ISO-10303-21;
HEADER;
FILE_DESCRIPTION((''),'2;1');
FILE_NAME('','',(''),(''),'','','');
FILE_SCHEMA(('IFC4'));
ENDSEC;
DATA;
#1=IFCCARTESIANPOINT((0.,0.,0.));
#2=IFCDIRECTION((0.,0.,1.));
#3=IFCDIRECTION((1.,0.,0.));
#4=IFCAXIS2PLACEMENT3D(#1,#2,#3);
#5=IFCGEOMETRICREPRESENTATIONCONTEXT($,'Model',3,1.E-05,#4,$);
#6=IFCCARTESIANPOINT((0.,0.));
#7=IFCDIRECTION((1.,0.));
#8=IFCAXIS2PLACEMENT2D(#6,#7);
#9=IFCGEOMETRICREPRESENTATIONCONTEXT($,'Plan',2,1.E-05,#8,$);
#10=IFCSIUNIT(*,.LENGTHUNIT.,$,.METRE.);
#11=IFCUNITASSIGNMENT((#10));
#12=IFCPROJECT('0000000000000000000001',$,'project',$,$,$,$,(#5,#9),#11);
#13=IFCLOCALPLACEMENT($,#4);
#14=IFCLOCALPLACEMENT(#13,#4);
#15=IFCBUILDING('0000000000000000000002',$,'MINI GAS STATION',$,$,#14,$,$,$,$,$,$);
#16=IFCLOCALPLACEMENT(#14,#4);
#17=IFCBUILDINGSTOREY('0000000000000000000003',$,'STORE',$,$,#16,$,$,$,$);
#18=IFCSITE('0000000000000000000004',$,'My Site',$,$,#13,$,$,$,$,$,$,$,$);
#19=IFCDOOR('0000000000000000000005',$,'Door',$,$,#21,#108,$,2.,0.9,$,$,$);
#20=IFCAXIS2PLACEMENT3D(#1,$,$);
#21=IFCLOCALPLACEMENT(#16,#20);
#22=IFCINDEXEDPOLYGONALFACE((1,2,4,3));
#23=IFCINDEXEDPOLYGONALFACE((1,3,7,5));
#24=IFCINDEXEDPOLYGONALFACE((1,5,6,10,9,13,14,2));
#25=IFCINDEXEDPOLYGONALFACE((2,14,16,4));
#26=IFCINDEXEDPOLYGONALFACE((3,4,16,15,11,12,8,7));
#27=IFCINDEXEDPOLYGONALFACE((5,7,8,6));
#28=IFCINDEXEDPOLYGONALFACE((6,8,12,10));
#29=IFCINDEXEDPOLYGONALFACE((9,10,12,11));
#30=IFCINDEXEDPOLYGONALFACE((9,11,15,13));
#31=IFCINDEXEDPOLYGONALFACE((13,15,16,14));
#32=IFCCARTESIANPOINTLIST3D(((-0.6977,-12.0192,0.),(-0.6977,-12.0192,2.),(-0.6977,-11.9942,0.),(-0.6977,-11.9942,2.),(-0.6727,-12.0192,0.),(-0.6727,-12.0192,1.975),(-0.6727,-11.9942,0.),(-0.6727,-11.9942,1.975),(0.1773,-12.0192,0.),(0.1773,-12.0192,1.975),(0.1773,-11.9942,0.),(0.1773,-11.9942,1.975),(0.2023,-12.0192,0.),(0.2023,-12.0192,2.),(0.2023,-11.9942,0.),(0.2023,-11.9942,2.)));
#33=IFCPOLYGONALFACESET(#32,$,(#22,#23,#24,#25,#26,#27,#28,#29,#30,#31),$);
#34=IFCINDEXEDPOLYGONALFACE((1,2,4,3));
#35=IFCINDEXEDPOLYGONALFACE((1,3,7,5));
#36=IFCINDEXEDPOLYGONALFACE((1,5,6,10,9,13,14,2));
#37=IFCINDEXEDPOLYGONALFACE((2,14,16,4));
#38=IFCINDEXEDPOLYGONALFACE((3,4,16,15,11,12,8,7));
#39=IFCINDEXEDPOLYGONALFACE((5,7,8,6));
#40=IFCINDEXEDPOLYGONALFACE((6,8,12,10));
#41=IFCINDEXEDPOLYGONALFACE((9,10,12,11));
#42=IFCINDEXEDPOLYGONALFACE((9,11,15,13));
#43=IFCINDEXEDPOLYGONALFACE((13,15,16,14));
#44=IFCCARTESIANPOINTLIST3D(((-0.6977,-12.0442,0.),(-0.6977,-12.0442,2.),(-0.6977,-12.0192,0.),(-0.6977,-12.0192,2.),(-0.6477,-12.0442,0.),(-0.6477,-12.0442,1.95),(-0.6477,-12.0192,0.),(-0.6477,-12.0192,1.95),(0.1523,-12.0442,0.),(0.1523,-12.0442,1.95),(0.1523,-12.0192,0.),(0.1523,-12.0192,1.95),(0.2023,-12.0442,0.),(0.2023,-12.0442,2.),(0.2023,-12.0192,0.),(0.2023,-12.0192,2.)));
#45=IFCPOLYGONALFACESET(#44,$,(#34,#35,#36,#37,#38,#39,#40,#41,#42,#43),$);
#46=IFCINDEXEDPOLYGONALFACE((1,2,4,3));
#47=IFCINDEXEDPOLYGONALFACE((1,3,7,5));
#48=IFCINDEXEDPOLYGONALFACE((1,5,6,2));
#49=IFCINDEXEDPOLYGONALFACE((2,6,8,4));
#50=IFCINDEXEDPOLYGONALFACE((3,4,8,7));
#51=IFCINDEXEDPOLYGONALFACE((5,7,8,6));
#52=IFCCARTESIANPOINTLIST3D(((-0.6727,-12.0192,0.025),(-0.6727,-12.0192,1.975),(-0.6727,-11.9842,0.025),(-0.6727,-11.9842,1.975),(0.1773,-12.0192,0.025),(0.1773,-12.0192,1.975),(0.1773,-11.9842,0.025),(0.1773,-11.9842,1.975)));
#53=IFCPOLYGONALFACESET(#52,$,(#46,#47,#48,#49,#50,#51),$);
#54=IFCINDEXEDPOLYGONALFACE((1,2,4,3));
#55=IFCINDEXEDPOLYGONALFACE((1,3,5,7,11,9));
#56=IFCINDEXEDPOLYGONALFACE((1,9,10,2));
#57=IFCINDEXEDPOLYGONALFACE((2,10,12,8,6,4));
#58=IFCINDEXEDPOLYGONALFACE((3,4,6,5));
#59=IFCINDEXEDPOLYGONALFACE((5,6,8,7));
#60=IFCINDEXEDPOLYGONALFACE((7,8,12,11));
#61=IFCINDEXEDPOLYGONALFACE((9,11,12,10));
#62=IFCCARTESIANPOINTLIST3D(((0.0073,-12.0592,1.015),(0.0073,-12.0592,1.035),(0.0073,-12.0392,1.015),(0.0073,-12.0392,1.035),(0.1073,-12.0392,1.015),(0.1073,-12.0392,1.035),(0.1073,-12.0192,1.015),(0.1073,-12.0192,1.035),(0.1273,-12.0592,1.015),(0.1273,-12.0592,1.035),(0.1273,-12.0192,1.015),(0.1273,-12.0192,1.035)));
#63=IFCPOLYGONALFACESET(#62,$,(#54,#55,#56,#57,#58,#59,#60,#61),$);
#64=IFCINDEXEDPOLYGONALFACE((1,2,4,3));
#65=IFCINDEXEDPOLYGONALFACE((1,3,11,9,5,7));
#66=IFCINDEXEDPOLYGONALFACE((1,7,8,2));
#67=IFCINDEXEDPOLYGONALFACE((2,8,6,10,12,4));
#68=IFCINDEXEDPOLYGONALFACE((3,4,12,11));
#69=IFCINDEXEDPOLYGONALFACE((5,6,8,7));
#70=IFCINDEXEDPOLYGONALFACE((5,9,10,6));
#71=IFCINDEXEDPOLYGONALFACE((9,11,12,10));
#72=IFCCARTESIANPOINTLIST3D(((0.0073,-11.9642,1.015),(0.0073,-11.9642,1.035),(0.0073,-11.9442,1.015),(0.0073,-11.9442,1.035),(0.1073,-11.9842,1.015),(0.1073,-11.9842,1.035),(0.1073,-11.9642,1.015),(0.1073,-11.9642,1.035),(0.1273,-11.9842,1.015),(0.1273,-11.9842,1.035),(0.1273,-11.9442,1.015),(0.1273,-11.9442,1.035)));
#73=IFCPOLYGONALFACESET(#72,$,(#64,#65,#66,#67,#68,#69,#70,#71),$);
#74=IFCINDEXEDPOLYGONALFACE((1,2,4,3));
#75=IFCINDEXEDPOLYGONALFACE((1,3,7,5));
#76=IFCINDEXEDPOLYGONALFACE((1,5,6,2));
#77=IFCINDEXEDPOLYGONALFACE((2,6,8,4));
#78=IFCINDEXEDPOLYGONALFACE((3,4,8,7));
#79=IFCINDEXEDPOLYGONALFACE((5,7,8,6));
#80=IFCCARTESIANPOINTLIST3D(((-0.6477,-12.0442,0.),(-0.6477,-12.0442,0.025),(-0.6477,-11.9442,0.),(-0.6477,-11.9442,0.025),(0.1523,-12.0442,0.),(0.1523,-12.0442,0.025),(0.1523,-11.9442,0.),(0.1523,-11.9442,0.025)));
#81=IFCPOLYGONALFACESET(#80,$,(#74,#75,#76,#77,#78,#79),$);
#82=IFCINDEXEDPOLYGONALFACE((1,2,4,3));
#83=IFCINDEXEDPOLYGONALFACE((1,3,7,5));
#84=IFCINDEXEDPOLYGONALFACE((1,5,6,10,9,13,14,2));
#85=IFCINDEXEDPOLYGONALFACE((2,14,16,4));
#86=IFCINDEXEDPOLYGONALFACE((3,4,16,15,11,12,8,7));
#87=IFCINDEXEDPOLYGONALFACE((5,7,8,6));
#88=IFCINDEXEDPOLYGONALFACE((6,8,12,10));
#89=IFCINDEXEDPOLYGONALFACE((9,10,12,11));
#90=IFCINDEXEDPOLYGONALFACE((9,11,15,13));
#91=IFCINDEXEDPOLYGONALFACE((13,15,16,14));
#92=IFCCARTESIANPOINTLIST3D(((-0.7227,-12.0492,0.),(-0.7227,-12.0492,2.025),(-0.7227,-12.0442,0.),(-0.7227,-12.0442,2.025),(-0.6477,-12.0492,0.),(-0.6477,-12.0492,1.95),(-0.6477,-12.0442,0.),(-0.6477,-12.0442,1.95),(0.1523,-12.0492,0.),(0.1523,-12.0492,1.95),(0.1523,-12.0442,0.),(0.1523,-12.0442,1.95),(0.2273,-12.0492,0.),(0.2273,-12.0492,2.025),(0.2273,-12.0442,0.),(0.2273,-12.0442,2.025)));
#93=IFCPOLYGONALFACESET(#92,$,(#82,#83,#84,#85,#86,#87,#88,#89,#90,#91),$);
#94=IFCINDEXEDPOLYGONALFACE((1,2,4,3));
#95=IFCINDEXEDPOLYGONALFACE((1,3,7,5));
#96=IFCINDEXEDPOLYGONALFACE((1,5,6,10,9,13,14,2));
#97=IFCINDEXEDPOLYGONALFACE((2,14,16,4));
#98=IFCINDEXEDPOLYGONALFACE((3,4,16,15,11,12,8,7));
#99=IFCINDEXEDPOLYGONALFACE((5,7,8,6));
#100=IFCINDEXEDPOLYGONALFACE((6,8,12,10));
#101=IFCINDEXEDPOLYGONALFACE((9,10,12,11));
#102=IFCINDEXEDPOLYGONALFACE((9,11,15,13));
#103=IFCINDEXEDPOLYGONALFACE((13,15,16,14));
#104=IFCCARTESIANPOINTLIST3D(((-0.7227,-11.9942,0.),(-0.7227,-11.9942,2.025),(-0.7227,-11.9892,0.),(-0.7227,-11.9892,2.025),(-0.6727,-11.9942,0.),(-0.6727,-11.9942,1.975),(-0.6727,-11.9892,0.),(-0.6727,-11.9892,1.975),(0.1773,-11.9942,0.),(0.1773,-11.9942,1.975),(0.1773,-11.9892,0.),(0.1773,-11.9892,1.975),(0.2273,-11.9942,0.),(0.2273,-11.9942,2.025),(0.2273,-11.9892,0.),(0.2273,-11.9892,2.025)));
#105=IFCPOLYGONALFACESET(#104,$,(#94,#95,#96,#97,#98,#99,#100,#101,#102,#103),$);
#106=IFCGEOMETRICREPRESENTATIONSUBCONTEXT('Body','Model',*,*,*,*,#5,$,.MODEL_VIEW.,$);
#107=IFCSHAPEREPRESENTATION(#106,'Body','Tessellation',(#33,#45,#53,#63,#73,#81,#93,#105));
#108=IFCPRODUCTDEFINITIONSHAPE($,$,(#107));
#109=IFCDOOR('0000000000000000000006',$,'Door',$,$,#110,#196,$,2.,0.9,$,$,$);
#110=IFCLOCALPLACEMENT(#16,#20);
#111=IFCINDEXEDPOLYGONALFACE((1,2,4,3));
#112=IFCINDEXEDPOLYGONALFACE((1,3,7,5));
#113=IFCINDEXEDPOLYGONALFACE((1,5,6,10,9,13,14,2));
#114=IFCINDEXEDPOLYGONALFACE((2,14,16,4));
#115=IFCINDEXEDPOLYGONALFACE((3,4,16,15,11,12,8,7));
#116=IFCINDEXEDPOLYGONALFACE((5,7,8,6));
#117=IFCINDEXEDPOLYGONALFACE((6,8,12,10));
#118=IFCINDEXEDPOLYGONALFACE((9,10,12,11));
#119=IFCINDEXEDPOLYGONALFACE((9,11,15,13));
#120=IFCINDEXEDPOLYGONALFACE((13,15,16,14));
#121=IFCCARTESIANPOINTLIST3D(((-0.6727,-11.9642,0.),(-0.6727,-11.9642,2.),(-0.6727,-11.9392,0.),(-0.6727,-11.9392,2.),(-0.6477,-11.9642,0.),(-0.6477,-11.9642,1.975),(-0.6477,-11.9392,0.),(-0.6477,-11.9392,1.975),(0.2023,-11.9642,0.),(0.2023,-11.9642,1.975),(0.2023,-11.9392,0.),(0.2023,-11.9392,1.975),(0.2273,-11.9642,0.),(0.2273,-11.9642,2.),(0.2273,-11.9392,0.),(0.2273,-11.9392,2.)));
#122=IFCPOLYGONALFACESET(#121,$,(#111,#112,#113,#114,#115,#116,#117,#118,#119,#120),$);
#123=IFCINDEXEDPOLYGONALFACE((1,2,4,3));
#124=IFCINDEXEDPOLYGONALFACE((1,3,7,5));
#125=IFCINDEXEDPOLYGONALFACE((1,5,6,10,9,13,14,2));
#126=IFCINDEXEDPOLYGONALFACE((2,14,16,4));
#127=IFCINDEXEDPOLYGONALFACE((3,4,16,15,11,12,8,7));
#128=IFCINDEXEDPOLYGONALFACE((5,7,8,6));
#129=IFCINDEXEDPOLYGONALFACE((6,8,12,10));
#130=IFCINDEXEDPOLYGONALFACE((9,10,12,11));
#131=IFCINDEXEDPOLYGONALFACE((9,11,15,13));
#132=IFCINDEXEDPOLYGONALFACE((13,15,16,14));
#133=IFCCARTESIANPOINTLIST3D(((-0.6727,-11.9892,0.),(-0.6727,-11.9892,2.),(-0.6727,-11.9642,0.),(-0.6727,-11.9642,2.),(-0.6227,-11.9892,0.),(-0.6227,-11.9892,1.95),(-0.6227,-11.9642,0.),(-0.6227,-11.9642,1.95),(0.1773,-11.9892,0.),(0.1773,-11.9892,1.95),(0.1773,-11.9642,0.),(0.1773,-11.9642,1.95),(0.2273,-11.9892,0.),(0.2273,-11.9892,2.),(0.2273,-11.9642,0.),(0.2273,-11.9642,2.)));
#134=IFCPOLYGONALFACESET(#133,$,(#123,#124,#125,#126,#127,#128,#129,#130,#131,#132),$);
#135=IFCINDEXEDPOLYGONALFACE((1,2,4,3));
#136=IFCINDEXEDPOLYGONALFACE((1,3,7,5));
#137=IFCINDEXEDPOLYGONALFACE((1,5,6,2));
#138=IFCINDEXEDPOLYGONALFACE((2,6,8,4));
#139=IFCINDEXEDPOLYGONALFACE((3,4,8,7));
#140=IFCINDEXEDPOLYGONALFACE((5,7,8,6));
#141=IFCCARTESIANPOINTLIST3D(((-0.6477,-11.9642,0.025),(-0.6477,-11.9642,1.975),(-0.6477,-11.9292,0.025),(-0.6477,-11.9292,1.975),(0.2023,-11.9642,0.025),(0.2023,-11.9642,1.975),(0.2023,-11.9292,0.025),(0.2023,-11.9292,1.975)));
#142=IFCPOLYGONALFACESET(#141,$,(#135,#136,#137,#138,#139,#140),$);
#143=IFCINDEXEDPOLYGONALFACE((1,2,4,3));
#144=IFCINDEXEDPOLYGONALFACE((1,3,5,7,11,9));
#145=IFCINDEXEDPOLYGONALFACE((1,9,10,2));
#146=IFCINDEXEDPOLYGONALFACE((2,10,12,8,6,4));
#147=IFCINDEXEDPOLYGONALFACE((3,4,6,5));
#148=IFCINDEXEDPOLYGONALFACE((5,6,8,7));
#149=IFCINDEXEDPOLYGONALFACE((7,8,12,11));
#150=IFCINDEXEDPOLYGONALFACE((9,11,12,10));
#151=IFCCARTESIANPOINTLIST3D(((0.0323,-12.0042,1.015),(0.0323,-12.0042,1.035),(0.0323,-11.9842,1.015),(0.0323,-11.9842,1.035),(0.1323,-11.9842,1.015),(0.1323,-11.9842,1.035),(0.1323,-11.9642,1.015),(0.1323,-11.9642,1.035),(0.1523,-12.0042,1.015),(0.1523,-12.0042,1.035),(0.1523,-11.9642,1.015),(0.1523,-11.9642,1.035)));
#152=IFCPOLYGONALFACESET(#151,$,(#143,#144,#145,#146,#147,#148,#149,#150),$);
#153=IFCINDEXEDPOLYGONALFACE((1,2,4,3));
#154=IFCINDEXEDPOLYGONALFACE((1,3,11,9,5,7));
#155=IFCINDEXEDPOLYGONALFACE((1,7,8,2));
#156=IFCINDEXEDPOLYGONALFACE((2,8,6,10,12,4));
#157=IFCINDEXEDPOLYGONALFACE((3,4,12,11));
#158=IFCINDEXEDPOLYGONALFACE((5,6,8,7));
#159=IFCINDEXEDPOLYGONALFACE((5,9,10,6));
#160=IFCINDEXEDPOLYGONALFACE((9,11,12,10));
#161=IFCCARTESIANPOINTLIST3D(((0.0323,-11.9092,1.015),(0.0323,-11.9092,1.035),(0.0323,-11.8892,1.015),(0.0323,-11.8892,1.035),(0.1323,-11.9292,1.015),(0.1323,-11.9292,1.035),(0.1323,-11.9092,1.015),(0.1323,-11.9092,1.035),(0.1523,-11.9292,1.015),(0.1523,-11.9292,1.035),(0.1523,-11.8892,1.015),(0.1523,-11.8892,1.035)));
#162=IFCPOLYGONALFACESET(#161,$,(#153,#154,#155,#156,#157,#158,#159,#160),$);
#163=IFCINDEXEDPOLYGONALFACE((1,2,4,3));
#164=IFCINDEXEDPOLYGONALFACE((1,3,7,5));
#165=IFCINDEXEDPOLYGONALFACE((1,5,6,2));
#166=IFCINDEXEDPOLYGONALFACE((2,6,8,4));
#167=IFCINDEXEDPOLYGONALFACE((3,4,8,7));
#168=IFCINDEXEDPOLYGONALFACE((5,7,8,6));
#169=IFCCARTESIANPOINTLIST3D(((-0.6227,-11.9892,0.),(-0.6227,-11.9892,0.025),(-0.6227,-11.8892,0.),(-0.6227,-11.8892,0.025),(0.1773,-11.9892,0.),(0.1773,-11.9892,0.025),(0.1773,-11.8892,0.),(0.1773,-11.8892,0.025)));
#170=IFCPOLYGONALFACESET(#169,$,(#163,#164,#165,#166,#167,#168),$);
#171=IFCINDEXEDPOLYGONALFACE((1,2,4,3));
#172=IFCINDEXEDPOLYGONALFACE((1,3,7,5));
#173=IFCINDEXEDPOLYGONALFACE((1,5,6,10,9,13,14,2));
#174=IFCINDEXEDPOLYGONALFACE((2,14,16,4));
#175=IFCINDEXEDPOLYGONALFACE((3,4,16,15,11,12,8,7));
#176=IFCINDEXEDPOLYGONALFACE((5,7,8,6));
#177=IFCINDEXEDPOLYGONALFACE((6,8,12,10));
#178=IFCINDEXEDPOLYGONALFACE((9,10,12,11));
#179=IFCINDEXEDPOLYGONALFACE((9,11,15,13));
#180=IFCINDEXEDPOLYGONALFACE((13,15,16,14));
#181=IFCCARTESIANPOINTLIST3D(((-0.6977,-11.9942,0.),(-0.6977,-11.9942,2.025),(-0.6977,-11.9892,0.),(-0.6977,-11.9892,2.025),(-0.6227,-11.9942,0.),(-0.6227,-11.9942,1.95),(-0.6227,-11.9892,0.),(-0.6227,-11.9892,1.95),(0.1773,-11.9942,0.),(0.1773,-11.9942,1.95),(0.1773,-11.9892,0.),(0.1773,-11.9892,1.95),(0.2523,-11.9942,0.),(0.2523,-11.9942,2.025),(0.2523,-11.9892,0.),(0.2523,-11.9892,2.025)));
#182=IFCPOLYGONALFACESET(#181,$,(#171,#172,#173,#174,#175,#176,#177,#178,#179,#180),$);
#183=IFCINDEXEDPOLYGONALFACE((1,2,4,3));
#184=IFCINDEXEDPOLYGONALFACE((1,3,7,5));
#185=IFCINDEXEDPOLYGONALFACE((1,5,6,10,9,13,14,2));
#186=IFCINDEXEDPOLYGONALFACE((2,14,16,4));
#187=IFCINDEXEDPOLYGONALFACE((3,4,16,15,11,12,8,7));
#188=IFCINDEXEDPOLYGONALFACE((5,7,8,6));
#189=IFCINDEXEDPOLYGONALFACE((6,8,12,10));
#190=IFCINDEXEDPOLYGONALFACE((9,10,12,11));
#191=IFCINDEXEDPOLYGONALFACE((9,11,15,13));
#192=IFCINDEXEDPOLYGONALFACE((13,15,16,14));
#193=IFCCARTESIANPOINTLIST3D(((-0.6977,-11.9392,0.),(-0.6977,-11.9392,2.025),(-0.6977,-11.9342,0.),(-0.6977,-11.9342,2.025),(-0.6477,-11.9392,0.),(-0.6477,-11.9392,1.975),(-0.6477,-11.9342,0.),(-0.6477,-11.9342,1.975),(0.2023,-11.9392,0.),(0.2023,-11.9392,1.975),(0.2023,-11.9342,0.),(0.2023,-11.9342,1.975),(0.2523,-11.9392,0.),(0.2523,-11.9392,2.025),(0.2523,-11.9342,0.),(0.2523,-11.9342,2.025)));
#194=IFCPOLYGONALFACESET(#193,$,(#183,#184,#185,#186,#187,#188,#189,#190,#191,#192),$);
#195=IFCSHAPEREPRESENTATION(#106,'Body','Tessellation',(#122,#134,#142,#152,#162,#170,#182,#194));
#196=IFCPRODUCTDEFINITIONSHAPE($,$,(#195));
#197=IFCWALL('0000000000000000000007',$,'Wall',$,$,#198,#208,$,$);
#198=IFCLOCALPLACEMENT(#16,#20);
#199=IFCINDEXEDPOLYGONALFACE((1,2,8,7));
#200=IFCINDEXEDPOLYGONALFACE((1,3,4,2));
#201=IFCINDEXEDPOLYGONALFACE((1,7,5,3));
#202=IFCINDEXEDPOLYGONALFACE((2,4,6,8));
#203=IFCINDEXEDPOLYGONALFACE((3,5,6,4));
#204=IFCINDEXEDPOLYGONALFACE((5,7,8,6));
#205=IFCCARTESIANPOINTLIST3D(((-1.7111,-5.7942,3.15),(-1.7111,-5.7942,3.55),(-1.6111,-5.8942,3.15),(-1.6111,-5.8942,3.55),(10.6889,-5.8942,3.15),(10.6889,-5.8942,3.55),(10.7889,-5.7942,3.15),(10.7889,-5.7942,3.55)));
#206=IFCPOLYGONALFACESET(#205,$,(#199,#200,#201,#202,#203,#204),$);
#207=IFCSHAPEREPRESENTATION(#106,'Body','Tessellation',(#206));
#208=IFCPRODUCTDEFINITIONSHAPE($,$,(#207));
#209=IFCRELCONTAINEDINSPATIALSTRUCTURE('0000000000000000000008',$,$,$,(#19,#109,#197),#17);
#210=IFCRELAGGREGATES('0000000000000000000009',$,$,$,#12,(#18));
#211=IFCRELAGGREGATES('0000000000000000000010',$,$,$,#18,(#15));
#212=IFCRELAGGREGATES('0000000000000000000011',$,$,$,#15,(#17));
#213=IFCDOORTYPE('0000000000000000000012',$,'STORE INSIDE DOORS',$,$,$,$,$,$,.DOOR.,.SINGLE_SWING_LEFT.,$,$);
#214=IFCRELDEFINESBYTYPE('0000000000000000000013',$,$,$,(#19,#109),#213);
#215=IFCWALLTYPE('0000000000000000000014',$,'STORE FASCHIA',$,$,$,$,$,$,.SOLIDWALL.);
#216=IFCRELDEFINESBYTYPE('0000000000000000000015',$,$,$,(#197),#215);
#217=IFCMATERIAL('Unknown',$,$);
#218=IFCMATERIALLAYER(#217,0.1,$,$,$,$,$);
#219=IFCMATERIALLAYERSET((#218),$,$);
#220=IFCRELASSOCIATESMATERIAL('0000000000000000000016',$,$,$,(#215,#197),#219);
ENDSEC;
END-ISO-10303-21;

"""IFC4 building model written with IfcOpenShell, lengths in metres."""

from ifc_helpers import new_model, entity, si_unit, frame, origin_with_axes, origin_2d_with_axis, place, context, subcontext, project, spatial, line, indexed_curve, outline, extrude, shape, source, transform, mapped, material, layer, layer_set, layer_usage, type_object, type_shapes, element, save


model = new_model("IFC4")

# Units and contexts
model_context = context("Model", 3, precision=1e-05, world=origin_with_axes())
plan_context = context("Plan", 2, precision=1e-05, world=origin_2d_with_axis())
body_context_1 = subcontext(model_context, "Body", "Model", "MODEL_VIEW")
body_context_2 = subcontext(plan_context, "Body", "Plan", "PLAN_VIEW")
ifc_project = project(units=[si_unit("LENGTHUNIT", "METRE")], contexts=[model_context, plan_context])

# Site, building, storey
site_placement = place(None, origin_with_axes())
site = spatial("IfcSite", under=ifc_project, at=site_placement, Name="My Site")
building_placement = place(site_placement, origin_with_axes())
building = spatial("IfcBuilding", under=site, at=building_placement, Name="MINI GAS STATION")
storey_placement = place(building_placement, origin_with_axes())
storey = spatial("IfcBuildingStorey", under=building, at=storey_placement, Name="STORE")

# Shared definitions
ifc_material = material(Name="Unknown")

# Shared definitions
door_type = type_object("IfcDoorType", Name="STORE INSIDE DOORS", OperationType="SINGLE_SWING_LEFT", PredefinedType="DOOR")
shared_shape_1 = source(origin_with_axes(), body_context_1, "Body", "SweptSolid", [
    extrude(outline(indexed_curve([(0.0, 0.0), (0.0, 2.0), (0.9, 2.0), (0.9, 0.0), (0.875, 0.0), (0.875, 1.975), (0.025, 1.975), (0.025, 0.0)], segments=[line(1, 2, 3, 4, 5, 6, 7, 8, 1)])), frame((0.0, 0.025, 0.0), z_axis=(0.0, -1.0, 0.0), x_axis=(1.0, 0.0, 0.0)), (0.0, 0.0, -1.0), 0.025),
    extrude(outline(indexed_curve([(0.0, 0.0), (0.0, 2.0), (0.9, 2.0), (0.9, 0.0), (0.85, 0.0), (0.85, 1.95), (0.05, 1.95), (0.05, 0.0)], segments=[line(1, 2, 3, 4, 5, 6, 7, 8, 1)])), frame((0.0, 0.0, 0.0), z_axis=(0.0, -1.0, 0.0), x_axis=(1.0, 0.0, 0.0)), (0.0, 0.0, -1.0), 0.025),
    extrude(outline(indexed_curve([(0.0, 0.0), (0.85, 0.0), (0.85, 0.035), (0.0, 0.035)], segments=[line(1, 2, 3, 4, 1)])), frame((0.025, 0.025, 0.025), z_axis=(0.0, 0.0, 1.0), x_axis=(1.0, 0.0, 0.0)), (0.0, 0.0, 1.0), 1.95),
    extrude(outline(indexed_curve([(0.0, 0.0), (0.0, -0.04), (-0.12, -0.04), (-0.12, -0.02), (-0.02, -0.02), (-0.02, 0.0)], segments=[line(1, 2, 3, 4, 5, 6, 1)])), frame((0.825, 0.025, 1.015), z_axis=(0.0, 0.0, 1.0), x_axis=(1.0, 0.0, 0.0)), (0.0, 0.0, 1.0), 0.02),
    extrude(outline(indexed_curve([(0.0, 0.0), (0.0, 0.04), (-0.12, 0.04), (-0.12, 0.02), (-0.02, 0.02), (-0.02, 0.0)], segments=[line(1, 2, 3, 4, 5, 6, 1)])), frame((0.825, 0.06, 1.015), z_axis=(0.0, 0.0, 1.0), x_axis=(1.0, 0.0, 0.0)), (0.0, 0.0, 1.0), 0.02),
    extrude(outline(indexed_curve([(0.0, 0.0), (0.8, 0.0), (0.8, 0.1), (0.0, 0.1)], segments=[line(1, 2, 3, 4, 1)])), frame((0.05, 0.0, 0.0), z_axis=(0.0, 0.0, 1.0), x_axis=(1.0, 0.0, 0.0)), (0.0, 0.0, 1.0), 0.025),
    extrude(outline(indexed_curve([(0.0, 0.0), (0.0, 2.025), (0.95, 2.025), (0.95, 0.0), (0.875, 0.0), (0.875, 1.95), (0.075, 1.95), (0.075, 0.0)], segments=[line(1, 2, 3, 4, 5, 6, 7, 8, 1)])), frame((-0.025, -0.005, 0.0), z_axis=(0.0, -1.0, 0.0), x_axis=(1.0, 0.0, 0.0)), (0.0, 0.0, -1.0), 0.005),
    extrude(outline(indexed_curve([(0.0, 0.0), (0.0, 2.025), (0.95, 2.025), (0.95, 0.0), (0.9, 0.0), (0.9, 1.975), (0.05, 1.975), (0.05, 0.0)], segments=[line(1, 2, 3, 4, 5, 6, 7, 8, 1)])), frame((-0.025, 0.05, 0.0), z_axis=(0.0, -1.0, 0.0), x_axis=(1.0, 0.0, 0.0)), (0.0, 0.0, -1.0), 0.005),
])
shared_shape_2 = source(origin_with_axes(), body_context_2, "Body", "Curve2D", [
    entity("IfcIndexedPolyCurve", entity("IfcCartesianPointList2D", [[0.0, 0.0], [0.0, 0.05], [0.025, 0.05], [0.025, 0.025], [0.05, 0.025], [0.05, 0.0]]), [entity("IfcLineIndex", [1, 2, 3, 4, 5, 6, 1])]),
    entity("IfcIndexedPolyCurve", entity("IfcCartesianPointList2D", [[0.9, 0.0], [0.9, 0.05], [0.875, 0.05], [0.875, 0.025], [0.85, 0.025], [0.85, 0.0]]), [entity("IfcLineIndex", [1, 2, 3, 4, 5, 6, 1])]),
    entity("IfcTrimmedCurve", entity("IfcEllipse", entity("IfcAxis2Placement2D", entity("IfcCartesianPoint", [0.06, 0.05]), entity("IfcDirection", [1.0, 0.0])), 0.815, 0.85), [entity("IfcCartesianPoint", [0.875, 0.05])], [entity("IfcCartesianPoint", [0.06, 0.9])], True, "CARTESIAN"),
    entity("IfcIndexedPolyCurve", entity("IfcCartesianPointList2D", [[0.025, 0.05], [0.06, 0.05], [0.06, 0.9], [0.025, 0.9]]), [entity("IfcLineIndex", [1, 2, 3, 4, 1])]),
])
type_shapes(door_type, [shared_shape_1, shared_shape_2])

# Doors
for number, where, z_axis, x_axis, name in (
    (1, (-0.6977, -12.0442, 0.0), (0.0, 0.0, 1.0), (1.0, 0.0, 0.0), "Door"),
    (2, (-0.6727, -11.9892, 0.0), (0.0, 0.0, 1.0), (1.0, 0.0, 0.0), "Door"),
):
    element("IfcDoor", number, at=place(storey_placement, frame(where, z_axis=z_axis, x_axis=x_axis)), inside=storey, type_object=door_type, Name=name, OverallHeight=2.0, OverallWidth=0.9, shapes=[
        shape(body_context_1, "Body", "MappedRepresentation", [mapped(shared_shape_1, transform((0.0, 0.0, 0.0), x_axis=(1.0, 0.0, 0.0), y_axis=(0.0, 1.0, 0.0), z_axis=(0.0, 0.0, 1.0), scale=1.0))]),
        shape(body_context_2, "Body", "MappedRepresentation", [mapped(shared_shape_2, transform((0.0, 0.0, 0.0), x_axis=(1.0, 0.0, 0.0), y_axis=(0.0, 1.0, 0.0), z_axis=(0.0, 0.0, 1.0), scale=1.0))]),
    ])

# Wall
ifc_layer_1 = layer(ifc_material, 0.1)
ifc_layer_set_1 = layer_set([ifc_layer_1])
ifc_layer_usage_1 = layer_usage(ifc_layer_set_1, "AXIS2", "POSITIVE", 0.0)
wall_type_1 = type_object("IfcWallType", Name="STORE FASCHIA", PredefinedType="SOLIDWALL", material=ifc_layer_set_1)
wall_1_placement = place(storey_placement, frame((-1.6111, -5.8942, 3.15), z_axis=(0.0, 0.0, 1.0), x_axis=(1.0, 0.0, 0.0)))
element("IfcWall", 3, at=wall_1_placement, inside=storey, type_object=wall_type_1, material=ifc_layer_usage_1, Name="Wall", context=body_context_1, shape_type="SweptSolid", body=[
    extrude(outline(indexed_curve([(0.0, 0.0), (-0.1, 0.1), (12.4, 0.1), (12.3, 0.0)], segments=[line(1, 2, 3, 4, 1)])), origin_with_axes(), (0.0, 0.0, 1.0), 0.4),
])

save(model, "model.ifc")
